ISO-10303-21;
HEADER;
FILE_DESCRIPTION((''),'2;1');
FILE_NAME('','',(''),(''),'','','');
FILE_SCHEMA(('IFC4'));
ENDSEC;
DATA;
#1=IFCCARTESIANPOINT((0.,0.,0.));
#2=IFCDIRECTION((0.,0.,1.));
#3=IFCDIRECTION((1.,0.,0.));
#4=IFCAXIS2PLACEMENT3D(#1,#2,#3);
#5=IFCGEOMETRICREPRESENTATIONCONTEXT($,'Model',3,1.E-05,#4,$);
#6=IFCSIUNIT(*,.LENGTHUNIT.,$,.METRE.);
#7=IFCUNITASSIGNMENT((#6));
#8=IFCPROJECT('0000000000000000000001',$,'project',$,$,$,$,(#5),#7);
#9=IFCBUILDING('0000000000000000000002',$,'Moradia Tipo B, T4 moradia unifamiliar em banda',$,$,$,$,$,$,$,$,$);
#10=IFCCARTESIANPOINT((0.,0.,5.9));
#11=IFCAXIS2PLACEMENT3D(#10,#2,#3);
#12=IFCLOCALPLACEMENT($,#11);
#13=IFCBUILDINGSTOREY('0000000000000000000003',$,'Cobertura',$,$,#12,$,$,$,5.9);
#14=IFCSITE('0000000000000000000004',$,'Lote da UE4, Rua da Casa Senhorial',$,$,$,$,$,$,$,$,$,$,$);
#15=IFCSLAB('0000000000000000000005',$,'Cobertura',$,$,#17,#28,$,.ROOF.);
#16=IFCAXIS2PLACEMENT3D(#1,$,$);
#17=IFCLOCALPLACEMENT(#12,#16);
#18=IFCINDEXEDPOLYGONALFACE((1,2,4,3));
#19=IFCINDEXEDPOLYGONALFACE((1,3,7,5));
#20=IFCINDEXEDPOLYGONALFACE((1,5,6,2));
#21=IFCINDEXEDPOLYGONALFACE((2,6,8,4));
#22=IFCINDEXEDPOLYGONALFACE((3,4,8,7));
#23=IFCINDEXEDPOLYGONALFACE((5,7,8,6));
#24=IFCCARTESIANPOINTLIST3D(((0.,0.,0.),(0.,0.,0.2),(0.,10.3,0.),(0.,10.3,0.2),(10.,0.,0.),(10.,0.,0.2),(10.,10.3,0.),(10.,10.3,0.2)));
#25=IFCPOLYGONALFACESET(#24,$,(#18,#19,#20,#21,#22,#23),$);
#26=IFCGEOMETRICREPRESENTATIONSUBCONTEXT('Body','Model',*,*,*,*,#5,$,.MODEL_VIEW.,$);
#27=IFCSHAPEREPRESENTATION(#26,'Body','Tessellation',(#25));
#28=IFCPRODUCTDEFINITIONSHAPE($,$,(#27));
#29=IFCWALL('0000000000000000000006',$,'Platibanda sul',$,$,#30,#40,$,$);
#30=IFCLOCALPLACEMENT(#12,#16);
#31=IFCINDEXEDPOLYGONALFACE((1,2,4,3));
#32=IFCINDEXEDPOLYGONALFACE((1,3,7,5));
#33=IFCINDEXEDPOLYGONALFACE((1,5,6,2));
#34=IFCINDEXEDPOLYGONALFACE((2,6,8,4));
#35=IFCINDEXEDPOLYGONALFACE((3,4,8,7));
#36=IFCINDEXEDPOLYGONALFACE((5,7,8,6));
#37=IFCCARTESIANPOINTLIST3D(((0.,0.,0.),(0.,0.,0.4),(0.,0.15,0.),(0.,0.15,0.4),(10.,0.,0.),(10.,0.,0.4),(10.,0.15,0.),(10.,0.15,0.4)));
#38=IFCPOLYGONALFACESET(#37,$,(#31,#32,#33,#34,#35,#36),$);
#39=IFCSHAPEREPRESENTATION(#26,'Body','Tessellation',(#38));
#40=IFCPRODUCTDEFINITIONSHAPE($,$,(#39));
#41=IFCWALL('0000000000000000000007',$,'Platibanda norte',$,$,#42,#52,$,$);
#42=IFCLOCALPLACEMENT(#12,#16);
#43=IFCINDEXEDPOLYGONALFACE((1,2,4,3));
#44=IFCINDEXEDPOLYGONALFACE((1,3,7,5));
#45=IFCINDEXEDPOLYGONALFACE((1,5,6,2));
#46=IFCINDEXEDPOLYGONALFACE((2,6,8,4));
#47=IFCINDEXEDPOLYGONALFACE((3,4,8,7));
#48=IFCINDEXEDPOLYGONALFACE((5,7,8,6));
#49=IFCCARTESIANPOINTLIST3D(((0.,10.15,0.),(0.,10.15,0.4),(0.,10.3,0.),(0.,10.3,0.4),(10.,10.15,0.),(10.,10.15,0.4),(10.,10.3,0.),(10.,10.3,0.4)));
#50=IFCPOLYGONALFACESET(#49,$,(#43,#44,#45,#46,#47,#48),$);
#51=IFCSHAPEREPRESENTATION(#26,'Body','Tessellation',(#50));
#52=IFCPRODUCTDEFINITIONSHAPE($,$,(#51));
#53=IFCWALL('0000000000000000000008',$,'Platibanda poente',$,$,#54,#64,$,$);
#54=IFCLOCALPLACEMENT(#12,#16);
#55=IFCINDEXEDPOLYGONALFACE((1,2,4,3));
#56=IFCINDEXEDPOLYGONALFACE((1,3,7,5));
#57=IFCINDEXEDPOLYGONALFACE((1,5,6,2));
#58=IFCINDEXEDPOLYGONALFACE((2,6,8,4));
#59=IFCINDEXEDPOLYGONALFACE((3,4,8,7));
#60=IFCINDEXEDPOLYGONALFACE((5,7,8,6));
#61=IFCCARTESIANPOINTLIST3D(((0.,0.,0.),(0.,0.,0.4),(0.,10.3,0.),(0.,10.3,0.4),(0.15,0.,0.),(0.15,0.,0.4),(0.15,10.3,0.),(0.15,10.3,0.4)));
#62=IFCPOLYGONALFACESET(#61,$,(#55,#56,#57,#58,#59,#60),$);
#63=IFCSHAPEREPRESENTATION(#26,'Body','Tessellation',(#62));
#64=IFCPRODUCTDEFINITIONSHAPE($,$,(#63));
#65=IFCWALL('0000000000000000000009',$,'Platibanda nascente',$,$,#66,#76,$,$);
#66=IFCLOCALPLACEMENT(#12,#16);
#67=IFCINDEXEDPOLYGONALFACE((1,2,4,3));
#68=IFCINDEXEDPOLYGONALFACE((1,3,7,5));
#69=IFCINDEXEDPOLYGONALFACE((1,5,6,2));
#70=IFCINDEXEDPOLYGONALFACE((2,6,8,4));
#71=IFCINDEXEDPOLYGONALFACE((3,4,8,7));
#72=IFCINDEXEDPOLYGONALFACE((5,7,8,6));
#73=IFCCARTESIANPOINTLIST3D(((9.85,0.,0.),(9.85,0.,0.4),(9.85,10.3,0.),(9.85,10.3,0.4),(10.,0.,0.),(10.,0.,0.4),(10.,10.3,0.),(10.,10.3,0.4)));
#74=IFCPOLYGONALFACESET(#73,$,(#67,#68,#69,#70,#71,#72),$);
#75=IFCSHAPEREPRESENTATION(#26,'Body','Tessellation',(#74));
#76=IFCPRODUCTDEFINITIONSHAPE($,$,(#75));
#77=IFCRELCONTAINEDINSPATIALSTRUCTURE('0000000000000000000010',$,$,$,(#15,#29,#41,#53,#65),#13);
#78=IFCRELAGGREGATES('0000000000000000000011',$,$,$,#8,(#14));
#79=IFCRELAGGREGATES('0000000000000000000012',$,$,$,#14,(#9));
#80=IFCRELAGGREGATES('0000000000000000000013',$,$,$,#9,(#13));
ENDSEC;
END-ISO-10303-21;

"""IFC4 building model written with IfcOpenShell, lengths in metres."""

from ifc_helpers import new_model, si_unit, frame, origin_with_axes, place, context, subcontext, project, spatial, indexed_curve, outline, extrude, element, save


model = new_model("IFC4")

# Units and contexts
model_context = context("Model", 3, precision=1e-05, world=origin_with_axes())
body_context = subcontext(model_context, "Body", "Model", "MODEL_VIEW")
ifc_project = project(units=[si_unit("LENGTHUNIT", "METRE")], contexts=[model_context])

# Site, building, storey
site = spatial("IfcSite", under=ifc_project, Name="Lote da UE4, Rua da Casa Senhorial")
building = spatial("IfcBuilding", under=site, Name="Moradia Tipo B, T4 moradia unifamiliar em banda")
storey_placement = place(None, frame((0.0, 0.0, 5.9), z_axis=(0.0, 0.0, 1.0), x_axis=(1.0, 0.0, 0.0)))
storey = spatial("IfcBuildingStorey", under=building, at=storey_placement, Name="Cobertura", Elevation=5.9)

# Slab
slab_placement = place(storey_placement, origin_with_axes())
element("IfcSlab", 1, at=slab_placement, inside=storey, Name="Cobertura", PredefinedType="ROOF", context=body_context, shape_type="SweptSolid", body=[
    extrude(outline(indexed_curve([(0.0, 0.0), (10.0, 0.0), (10.0, 10.3), (0.0, 10.3), (0.0, 0.0)])), None, (0.0, 0.0, 1.0), 0.2),
])

# Walls
for number, where, z_axis, x_axis, name in (
    (2, (0.0, 0.0, 0.0), (0.0, 0.0, 1.0), (1.0, 0.0, 0.0), "Platibanda sul"),
    (3, (0.0, 10.15, 0.0), (0.0, 0.0, 1.0), (1.0, 0.0, 0.0), "Platibanda norte"),
):
    element("IfcWall", number, at=place(storey_placement, frame(where, z_axis=z_axis, x_axis=x_axis)), inside=storey, Name=name, context=body_context, shape_type="SweptSolid", body=[
        extrude(outline(indexed_curve([(0.0, 0.0), (0.0, 0.15), (10.0, 0.15), (10.0, 0.0), (0.0, 0.0)], self_intersect=False)), origin_with_axes(), (0.0, 0.0, 1.0), 0.4),
    ])
for number, where, z_axis, x_axis, name in (
    (4, (0.15, 0.0, 0.0), (0.0, 0.0, 1.0), (0.0, 1.0, 0.0), "Platibanda poente"),
    (5, (10.0, 0.0, 0.0), (0.0, 0.0, 1.0), (0.0, 1.0, 0.0), "Platibanda nascente"),
):
    element("IfcWall", number, at=place(storey_placement, frame(where, z_axis=z_axis, x_axis=x_axis)), inside=storey, Name=name, context=body_context, shape_type="SweptSolid", body=[
        extrude(outline(indexed_curve([(0.0, 0.0), (0.0, 0.15), (10.3, 0.15), (10.3, 0.0), (0.0, 0.0)], self_intersect=False)), origin_with_axes(), (0.0, 0.0, 1.0), 0.4),
    ])

save(model, "model.ifc")
